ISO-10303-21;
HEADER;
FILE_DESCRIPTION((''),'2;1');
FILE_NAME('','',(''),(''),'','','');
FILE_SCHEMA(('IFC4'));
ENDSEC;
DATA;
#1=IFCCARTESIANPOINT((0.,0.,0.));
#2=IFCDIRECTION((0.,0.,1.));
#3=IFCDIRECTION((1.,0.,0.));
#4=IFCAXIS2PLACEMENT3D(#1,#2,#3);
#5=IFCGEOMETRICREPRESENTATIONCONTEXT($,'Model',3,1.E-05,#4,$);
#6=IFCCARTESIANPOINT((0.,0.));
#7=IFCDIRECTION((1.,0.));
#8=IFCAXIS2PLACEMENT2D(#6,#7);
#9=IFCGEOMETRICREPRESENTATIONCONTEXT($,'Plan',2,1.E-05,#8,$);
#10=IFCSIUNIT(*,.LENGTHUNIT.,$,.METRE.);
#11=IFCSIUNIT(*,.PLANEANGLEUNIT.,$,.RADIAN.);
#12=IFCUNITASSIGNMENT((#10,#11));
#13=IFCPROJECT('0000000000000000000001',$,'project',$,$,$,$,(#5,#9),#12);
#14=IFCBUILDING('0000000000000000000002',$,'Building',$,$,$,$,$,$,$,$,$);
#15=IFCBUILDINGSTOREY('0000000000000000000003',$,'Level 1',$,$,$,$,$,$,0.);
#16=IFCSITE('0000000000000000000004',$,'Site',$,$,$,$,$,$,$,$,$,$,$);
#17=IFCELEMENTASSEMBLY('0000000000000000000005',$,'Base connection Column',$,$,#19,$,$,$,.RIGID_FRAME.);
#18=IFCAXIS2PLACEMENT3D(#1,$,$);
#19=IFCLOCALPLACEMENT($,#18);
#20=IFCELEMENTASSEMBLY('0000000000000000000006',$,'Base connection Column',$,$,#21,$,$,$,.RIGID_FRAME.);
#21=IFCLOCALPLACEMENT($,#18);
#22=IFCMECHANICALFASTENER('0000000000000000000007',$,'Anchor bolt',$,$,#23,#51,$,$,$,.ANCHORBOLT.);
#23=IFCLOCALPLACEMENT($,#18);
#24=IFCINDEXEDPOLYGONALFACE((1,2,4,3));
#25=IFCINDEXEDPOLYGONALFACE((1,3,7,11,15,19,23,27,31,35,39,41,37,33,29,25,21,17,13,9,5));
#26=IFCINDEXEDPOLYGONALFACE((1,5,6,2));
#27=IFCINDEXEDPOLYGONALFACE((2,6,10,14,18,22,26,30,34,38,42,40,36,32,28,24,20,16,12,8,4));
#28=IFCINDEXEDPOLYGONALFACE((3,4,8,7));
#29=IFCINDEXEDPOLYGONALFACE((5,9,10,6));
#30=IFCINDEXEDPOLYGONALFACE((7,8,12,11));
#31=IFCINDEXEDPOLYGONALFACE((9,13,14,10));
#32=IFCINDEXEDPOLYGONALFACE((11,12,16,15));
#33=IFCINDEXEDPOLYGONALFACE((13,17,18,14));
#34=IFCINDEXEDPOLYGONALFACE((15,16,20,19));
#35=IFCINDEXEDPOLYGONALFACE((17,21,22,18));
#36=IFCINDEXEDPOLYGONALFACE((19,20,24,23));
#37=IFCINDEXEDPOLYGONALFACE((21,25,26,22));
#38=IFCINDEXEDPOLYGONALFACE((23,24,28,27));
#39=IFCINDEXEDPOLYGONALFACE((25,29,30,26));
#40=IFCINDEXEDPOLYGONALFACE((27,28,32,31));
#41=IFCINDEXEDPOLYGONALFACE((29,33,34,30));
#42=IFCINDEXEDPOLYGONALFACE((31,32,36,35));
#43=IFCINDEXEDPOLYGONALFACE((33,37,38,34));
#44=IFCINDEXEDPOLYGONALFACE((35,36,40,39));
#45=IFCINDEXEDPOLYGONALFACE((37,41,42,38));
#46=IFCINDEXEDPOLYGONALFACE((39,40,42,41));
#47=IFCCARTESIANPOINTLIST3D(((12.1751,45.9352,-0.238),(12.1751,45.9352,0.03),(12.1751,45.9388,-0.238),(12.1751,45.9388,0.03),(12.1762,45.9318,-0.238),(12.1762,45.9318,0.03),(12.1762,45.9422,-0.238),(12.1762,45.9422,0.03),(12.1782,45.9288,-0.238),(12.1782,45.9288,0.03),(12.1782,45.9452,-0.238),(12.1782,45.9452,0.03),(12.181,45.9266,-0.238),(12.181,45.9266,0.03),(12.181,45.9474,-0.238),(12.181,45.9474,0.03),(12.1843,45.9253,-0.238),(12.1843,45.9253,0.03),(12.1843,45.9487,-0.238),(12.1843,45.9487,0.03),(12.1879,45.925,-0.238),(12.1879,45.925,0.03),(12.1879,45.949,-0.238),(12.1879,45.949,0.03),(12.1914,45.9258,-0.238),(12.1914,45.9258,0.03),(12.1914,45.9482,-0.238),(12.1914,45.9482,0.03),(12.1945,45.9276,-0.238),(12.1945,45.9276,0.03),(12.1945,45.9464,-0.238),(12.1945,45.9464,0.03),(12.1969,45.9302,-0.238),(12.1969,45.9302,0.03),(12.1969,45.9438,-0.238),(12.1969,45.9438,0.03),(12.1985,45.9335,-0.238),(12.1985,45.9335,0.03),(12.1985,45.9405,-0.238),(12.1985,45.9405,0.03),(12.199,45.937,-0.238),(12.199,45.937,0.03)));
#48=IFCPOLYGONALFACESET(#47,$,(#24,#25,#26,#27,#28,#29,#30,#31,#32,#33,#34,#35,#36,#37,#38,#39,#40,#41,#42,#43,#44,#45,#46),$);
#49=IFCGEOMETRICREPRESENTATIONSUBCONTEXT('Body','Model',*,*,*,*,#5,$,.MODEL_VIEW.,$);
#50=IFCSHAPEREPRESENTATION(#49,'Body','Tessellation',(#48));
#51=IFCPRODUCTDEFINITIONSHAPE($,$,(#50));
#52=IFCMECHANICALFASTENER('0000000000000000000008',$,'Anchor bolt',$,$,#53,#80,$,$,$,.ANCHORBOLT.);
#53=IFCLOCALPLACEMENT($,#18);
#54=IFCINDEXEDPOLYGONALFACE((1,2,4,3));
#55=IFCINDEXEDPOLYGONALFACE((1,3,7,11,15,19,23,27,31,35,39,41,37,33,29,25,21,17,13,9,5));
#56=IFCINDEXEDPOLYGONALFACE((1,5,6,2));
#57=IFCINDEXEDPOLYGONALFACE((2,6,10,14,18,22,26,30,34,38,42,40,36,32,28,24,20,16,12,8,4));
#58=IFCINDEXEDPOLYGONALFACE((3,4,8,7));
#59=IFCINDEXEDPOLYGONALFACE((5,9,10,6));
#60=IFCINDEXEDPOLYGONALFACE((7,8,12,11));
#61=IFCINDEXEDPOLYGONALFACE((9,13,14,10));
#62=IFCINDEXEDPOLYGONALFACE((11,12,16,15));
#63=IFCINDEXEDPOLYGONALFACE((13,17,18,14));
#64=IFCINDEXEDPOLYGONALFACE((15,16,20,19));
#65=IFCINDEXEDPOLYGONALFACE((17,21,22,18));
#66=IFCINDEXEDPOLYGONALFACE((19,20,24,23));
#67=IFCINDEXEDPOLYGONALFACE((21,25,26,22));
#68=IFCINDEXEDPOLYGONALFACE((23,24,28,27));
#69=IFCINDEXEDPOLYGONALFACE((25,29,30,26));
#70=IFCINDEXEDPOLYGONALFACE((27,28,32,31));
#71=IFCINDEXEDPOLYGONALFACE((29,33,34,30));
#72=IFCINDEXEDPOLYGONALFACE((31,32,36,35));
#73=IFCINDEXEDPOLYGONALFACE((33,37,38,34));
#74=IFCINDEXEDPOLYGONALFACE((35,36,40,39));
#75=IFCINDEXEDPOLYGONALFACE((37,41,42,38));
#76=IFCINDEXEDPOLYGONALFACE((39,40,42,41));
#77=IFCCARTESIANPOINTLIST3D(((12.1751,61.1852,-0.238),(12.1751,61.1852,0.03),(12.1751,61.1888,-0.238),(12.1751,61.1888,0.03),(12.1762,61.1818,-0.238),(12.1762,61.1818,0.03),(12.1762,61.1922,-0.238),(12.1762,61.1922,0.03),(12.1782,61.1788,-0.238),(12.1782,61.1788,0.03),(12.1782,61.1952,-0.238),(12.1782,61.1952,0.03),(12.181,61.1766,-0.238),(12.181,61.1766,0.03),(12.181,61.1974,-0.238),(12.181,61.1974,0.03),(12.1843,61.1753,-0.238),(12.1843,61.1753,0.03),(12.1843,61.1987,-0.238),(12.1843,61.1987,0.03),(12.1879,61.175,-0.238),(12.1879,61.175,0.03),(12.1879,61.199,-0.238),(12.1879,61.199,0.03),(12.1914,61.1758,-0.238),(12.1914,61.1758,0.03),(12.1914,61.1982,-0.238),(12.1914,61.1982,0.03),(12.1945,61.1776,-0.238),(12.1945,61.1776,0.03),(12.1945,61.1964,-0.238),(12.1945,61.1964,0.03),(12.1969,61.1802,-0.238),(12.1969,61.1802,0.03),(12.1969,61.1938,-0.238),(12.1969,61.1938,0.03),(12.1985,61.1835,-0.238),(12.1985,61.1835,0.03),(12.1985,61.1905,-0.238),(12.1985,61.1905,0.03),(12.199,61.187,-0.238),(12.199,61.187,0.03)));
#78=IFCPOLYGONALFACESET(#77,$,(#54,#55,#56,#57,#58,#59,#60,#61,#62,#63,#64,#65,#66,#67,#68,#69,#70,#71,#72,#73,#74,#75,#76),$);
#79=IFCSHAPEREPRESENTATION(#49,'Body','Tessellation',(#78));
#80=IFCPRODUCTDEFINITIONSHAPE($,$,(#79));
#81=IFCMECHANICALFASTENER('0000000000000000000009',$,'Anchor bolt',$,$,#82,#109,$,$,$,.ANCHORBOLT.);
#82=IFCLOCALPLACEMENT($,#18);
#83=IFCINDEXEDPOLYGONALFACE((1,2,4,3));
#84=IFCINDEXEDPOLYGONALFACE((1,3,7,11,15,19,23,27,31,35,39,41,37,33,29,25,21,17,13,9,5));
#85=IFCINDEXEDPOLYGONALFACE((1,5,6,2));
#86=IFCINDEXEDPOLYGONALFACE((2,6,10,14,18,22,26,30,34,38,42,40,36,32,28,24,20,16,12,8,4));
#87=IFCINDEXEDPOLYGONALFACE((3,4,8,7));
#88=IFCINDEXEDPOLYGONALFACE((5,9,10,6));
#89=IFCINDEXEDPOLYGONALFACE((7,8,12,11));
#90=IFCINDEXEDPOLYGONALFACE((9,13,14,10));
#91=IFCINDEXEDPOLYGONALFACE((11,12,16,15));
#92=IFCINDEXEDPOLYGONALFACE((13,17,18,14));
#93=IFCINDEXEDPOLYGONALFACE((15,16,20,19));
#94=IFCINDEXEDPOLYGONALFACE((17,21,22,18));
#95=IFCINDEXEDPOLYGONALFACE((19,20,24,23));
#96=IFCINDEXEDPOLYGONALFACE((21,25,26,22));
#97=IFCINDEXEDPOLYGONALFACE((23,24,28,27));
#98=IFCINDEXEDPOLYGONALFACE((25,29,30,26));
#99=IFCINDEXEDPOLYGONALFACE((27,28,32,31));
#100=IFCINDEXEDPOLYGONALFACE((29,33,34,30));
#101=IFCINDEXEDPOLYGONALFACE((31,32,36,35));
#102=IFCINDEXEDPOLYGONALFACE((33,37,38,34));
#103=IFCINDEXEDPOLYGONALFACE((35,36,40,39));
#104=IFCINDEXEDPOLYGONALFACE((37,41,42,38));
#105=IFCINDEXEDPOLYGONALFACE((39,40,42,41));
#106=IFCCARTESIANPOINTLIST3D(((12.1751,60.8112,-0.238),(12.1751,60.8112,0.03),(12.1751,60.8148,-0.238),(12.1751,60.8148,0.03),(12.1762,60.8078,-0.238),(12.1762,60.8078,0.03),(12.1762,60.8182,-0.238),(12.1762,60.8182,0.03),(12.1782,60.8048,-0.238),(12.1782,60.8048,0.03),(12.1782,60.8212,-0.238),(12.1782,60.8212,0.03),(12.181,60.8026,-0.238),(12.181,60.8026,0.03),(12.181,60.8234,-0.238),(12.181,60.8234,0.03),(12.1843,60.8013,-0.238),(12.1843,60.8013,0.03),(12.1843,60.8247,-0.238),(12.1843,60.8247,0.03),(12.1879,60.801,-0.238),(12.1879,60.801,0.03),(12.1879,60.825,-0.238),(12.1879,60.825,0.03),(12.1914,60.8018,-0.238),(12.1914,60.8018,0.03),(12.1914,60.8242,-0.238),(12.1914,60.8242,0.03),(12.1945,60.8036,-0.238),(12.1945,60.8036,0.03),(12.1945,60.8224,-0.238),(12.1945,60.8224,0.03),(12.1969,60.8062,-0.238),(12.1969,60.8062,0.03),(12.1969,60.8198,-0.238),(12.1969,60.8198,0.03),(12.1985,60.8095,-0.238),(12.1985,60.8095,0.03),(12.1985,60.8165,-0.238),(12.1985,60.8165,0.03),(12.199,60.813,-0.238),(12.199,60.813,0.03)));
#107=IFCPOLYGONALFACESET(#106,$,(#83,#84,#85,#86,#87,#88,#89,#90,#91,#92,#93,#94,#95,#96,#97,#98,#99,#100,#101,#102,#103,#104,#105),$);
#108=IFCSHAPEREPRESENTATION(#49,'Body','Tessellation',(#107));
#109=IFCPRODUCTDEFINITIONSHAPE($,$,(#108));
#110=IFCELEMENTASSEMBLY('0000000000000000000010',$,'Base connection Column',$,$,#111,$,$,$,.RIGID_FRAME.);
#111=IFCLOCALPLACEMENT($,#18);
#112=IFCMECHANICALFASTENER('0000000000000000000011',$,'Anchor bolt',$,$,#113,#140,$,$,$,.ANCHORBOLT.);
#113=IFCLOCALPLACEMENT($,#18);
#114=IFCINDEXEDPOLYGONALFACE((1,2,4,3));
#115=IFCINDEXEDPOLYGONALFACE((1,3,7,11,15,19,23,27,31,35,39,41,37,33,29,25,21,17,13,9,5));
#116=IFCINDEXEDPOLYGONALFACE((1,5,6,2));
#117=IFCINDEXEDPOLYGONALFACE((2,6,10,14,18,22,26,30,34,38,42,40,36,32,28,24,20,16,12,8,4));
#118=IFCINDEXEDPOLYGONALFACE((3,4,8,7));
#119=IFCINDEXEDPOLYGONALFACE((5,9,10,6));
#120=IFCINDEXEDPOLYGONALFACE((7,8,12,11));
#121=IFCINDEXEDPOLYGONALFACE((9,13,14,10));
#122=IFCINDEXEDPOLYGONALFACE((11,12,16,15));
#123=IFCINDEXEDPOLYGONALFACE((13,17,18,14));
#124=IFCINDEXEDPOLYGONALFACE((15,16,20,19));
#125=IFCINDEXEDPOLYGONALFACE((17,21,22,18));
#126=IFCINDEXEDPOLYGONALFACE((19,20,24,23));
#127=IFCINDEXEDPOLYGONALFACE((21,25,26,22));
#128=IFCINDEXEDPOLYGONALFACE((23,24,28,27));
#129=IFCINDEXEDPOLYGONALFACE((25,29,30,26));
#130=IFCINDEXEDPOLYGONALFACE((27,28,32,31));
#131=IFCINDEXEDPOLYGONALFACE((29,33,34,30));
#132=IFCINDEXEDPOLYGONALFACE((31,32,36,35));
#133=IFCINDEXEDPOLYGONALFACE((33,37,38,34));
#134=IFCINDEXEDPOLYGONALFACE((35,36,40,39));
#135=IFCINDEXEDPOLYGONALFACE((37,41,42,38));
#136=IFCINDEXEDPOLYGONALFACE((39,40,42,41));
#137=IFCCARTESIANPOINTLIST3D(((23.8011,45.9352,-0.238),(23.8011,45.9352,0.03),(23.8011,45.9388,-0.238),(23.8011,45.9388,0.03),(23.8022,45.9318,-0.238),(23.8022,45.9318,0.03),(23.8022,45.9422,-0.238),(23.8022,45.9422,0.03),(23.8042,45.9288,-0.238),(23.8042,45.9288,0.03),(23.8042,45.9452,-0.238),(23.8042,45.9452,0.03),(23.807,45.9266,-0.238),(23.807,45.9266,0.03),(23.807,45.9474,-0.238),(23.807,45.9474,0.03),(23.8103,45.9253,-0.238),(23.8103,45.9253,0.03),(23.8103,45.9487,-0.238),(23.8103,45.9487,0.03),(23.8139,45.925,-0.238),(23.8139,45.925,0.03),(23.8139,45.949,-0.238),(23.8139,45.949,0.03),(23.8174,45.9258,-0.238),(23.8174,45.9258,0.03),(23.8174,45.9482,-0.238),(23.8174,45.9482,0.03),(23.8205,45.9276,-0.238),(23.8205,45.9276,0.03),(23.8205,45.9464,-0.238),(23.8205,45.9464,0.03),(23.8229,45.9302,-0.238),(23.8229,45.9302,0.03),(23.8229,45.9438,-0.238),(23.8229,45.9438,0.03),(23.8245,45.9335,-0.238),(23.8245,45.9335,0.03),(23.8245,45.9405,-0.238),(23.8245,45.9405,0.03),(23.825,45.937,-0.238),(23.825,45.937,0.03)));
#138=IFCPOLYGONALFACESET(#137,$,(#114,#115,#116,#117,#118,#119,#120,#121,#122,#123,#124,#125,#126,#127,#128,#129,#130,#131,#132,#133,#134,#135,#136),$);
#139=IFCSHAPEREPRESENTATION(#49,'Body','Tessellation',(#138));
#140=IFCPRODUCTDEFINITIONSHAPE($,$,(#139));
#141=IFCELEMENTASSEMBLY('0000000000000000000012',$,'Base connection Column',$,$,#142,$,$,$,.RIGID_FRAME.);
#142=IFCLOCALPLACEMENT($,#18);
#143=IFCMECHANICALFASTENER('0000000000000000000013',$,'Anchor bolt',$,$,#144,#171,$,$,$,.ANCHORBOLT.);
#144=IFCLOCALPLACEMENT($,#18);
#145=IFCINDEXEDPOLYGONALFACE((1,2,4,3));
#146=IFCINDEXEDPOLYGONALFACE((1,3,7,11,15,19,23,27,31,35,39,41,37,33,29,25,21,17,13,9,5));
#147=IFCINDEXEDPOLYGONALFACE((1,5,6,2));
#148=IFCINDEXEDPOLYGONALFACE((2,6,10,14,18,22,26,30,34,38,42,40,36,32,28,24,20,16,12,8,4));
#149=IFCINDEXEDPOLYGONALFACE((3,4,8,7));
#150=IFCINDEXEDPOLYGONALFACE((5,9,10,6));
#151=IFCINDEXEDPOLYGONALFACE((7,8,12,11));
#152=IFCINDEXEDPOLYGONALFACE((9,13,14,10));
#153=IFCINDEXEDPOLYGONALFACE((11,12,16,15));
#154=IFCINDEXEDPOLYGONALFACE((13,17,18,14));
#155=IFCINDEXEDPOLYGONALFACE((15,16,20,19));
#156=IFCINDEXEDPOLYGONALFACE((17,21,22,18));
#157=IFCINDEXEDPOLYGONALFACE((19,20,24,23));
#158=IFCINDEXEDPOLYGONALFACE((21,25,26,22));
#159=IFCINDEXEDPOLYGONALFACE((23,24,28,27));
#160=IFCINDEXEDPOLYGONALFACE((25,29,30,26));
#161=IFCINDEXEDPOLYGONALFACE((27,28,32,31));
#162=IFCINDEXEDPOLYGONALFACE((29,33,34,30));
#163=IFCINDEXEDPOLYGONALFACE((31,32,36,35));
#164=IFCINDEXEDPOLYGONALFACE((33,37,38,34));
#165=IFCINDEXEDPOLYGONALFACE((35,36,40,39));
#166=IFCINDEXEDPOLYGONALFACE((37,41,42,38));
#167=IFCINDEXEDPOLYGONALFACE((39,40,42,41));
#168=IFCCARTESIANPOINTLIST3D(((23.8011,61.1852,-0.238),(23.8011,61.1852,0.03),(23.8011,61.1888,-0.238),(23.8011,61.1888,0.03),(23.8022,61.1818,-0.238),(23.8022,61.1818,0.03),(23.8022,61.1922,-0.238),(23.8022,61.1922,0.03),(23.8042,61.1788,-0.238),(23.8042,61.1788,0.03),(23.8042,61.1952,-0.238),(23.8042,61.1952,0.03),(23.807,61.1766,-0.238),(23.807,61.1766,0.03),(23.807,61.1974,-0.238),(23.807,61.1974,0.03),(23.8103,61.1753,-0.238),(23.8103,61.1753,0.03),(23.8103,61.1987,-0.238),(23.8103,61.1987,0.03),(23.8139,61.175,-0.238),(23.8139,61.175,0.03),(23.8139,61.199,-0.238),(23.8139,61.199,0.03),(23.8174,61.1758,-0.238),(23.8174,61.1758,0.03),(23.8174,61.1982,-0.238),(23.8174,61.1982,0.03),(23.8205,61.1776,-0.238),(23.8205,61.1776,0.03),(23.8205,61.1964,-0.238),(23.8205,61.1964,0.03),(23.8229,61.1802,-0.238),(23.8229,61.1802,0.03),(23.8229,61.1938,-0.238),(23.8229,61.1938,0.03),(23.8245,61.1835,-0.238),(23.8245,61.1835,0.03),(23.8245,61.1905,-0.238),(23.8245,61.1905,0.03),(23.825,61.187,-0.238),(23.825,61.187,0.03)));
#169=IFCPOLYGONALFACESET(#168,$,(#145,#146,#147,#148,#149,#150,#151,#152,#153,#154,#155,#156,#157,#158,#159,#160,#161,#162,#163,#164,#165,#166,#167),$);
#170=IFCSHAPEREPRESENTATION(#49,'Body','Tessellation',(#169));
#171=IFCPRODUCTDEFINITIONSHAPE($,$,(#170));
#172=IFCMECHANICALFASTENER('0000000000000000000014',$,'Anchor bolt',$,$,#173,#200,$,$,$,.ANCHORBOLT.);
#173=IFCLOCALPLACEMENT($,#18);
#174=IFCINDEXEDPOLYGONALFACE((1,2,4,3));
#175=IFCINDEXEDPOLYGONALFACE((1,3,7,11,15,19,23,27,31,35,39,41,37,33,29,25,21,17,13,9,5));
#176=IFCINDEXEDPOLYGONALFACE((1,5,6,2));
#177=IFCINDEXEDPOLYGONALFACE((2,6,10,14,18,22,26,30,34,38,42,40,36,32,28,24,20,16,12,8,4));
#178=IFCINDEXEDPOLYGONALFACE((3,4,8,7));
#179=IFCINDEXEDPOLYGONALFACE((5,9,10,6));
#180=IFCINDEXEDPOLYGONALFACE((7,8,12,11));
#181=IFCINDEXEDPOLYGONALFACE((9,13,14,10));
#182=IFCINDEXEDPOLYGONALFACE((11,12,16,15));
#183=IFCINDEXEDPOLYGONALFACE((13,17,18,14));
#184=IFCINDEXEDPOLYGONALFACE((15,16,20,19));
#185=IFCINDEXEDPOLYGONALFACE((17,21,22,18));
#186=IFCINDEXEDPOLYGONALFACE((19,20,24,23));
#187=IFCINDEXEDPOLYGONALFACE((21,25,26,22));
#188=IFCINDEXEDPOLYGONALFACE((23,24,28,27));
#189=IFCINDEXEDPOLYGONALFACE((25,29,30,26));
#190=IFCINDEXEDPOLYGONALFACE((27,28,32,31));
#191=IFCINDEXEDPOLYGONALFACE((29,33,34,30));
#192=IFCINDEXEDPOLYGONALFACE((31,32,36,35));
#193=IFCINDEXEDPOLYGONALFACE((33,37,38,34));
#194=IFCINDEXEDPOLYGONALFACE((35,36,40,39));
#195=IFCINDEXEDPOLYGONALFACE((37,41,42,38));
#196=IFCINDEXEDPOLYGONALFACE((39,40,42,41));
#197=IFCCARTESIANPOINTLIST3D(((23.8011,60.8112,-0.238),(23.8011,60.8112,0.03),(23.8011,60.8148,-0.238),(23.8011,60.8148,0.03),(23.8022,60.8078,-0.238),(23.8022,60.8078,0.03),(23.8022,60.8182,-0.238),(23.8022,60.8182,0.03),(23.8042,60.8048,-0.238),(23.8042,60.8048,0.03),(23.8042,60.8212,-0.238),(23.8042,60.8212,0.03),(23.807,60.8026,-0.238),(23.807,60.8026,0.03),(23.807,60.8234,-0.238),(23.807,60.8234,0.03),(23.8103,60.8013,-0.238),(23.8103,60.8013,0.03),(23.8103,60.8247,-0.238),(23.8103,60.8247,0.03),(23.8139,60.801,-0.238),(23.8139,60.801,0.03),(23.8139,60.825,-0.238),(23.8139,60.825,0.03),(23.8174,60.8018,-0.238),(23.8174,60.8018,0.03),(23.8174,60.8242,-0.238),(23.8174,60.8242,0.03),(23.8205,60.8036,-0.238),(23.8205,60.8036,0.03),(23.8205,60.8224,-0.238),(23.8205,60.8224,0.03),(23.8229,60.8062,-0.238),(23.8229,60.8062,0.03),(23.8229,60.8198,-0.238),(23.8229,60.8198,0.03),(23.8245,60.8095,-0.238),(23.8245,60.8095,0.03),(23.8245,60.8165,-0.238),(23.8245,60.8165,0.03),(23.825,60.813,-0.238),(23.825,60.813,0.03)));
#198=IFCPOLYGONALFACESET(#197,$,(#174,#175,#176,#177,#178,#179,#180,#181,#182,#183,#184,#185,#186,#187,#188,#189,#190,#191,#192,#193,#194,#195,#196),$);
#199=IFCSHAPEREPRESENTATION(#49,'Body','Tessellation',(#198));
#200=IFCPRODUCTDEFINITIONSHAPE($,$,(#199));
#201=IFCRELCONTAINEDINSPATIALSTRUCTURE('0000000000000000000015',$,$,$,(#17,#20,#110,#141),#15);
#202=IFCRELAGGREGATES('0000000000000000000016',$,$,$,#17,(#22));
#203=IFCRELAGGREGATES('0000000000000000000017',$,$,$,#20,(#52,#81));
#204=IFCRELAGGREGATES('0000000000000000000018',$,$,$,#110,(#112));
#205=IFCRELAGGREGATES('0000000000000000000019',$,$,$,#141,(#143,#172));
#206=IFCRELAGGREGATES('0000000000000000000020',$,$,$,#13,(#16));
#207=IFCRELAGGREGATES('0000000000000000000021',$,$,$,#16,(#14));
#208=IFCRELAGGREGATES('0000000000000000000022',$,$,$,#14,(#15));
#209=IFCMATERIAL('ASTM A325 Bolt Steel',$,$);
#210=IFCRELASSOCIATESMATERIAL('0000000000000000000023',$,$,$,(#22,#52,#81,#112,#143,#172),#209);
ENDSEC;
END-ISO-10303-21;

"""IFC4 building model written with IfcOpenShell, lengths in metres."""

from ifc_helpers import new_model, si_unit, frame, origin_with_axes, origin_2d, origin_2d_with_axis, place, context, subcontext, project, spatial, circle, extrude, material, element, aggregate, save


model = new_model("IFC4")

# Units and contexts
model_context = context("Model", 3, precision=1e-05, world=origin_with_axes())
plan_context = context("Plan", 2, precision=1e-05, world=origin_2d_with_axis())
body_context = subcontext(model_context, "Body", "Model", "MODEL_VIEW")
ifc_project = project(units=[si_unit("LENGTHUNIT", "METRE"), si_unit("PLANEANGLEUNIT", "RADIAN")], contexts=[model_context, plan_context])

# Site, building, storey
site = spatial("IfcSite", under=ifc_project, Name="Site")
building = spatial("IfcBuilding", under=site, Name="Building")
storey = spatial("IfcBuildingStorey", under=building, Name="Level 1", Elevation=0.0)

# Element assemblies
assembly_1 = element("IfcElementAssembly", 1, inside=storey, Name="Base connection Column", PredefinedType="RIGID_FRAME")
assembly_2 = element("IfcElementAssembly", 2, inside=storey, Name="Base connection Column", PredefinedType="RIGID_FRAME")

# Mechanical fasteners
ifc_material_1 = material(Name="ASTM A325 Bolt Steel")
mechanical_fastener_1_placement = place(None, frame((12.187, 45.937, -0.238), z_axis=(0.0, 0.0, 1.0), x_axis=(1.0, 0.0, 0.0)))
mechanical_fastener_1 = element("IfcMechanicalFastener", 3, at=mechanical_fastener_1_placement, material=ifc_material_1, Name="Anchor bolt", PredefinedType="ANCHORBOLT", context=body_context, shape_type="SweptSolid", body=[
    extrude(circle(Radius=0.012, at=origin_2d()), origin_with_axes(), (0.0, 0.0, 1.0), 0.268),
])
aggregate(assembly_1, [mechanical_fastener_1])
mechanical_fastener_2_placement = place(None, frame((12.187, 61.187, -0.238), z_axis=(0.0, 0.0, 1.0), x_axis=(1.0, 0.0, 0.0)))
mechanical_fastener_2 = element("IfcMechanicalFastener", 4, at=mechanical_fastener_2_placement, material=ifc_material_1, Name="Anchor bolt", PredefinedType="ANCHORBOLT", context=body_context, shape_type="SweptSolid", body=[
    extrude(circle(Radius=0.012, at=origin_2d()), origin_with_axes(), (0.0, 0.0, 1.0), 0.268),
])
mechanical_fastener_3_placement = place(None, frame((12.187, 60.813, -0.238), z_axis=(0.0, 0.0, 1.0), x_axis=(1.0, 0.0, 0.0)))
mechanical_fastener_3 = element("IfcMechanicalFastener", 5, at=mechanical_fastener_3_placement, material=ifc_material_1, Name="Anchor bolt", PredefinedType="ANCHORBOLT", context=body_context, shape_type="SweptSolid", body=[
    extrude(circle(Radius=0.012, at=origin_2d()), origin_with_axes(), (0.0, 0.0, 1.0), 0.268),
])
aggregate(assembly_2, [mechanical_fastener_2, mechanical_fastener_3])

# Element assembly, mechanical fastener
assembly_3 = element("IfcElementAssembly", 6, inside=storey, Name="Base connection Column", PredefinedType="RIGID_FRAME")
mechanical_fastener_4_placement = place(None, frame((23.813, 45.937, -0.238), z_axis=(0.0, 0.0, 1.0), x_axis=(1.0, 0.0, 0.0)))
mechanical_fastener_4 = element("IfcMechanicalFastener", 7, at=mechanical_fastener_4_placement, material=ifc_material_1, Name="Anchor bolt", PredefinedType="ANCHORBOLT", context=body_context, shape_type="SweptSolid", body=[
    extrude(circle(Radius=0.012, at=origin_2d()), origin_with_axes(), (0.0, 0.0, 1.0), 0.268),
])
aggregate(assembly_3, [mechanical_fastener_4])

# Element assembly, mechanical fasteners
assembly_4 = element("IfcElementAssembly", 8, inside=storey, Name="Base connection Column", PredefinedType="RIGID_FRAME")
mechanical_fastener_5_placement = place(None, frame((23.813, 61.187, -0.238), z_axis=(0.0, 0.0, 1.0), x_axis=(1.0, 0.0, 0.0)))
mechanical_fastener_5 = element("IfcMechanicalFastener", 9, at=mechanical_fastener_5_placement, material=ifc_material_1, Name="Anchor bolt", PredefinedType="ANCHORBOLT", context=body_context, shape_type="SweptSolid", body=[
    extrude(circle(Radius=0.012, at=origin_2d()), origin_with_axes(), (0.0, 0.0, 1.0), 0.268),
])
mechanical_fastener_6_placement = place(None, frame((23.813, 60.813, -0.238), z_axis=(0.0, 0.0, 1.0), x_axis=(1.0, 0.0, 0.0)))
mechanical_fastener_6 = element("IfcMechanicalFastener", 10, at=mechanical_fastener_6_placement, material=ifc_material_1, Name="Anchor bolt", PredefinedType="ANCHORBOLT", context=body_context, shape_type="SweptSolid", body=[
    extrude(circle(Radius=0.012, at=origin_2d()), origin_with_axes(), (0.0, 0.0, 1.0), 0.268),
])
aggregate(assembly_4, [mechanical_fastener_5, mechanical_fastener_6])

save(model, "model.ifc")
